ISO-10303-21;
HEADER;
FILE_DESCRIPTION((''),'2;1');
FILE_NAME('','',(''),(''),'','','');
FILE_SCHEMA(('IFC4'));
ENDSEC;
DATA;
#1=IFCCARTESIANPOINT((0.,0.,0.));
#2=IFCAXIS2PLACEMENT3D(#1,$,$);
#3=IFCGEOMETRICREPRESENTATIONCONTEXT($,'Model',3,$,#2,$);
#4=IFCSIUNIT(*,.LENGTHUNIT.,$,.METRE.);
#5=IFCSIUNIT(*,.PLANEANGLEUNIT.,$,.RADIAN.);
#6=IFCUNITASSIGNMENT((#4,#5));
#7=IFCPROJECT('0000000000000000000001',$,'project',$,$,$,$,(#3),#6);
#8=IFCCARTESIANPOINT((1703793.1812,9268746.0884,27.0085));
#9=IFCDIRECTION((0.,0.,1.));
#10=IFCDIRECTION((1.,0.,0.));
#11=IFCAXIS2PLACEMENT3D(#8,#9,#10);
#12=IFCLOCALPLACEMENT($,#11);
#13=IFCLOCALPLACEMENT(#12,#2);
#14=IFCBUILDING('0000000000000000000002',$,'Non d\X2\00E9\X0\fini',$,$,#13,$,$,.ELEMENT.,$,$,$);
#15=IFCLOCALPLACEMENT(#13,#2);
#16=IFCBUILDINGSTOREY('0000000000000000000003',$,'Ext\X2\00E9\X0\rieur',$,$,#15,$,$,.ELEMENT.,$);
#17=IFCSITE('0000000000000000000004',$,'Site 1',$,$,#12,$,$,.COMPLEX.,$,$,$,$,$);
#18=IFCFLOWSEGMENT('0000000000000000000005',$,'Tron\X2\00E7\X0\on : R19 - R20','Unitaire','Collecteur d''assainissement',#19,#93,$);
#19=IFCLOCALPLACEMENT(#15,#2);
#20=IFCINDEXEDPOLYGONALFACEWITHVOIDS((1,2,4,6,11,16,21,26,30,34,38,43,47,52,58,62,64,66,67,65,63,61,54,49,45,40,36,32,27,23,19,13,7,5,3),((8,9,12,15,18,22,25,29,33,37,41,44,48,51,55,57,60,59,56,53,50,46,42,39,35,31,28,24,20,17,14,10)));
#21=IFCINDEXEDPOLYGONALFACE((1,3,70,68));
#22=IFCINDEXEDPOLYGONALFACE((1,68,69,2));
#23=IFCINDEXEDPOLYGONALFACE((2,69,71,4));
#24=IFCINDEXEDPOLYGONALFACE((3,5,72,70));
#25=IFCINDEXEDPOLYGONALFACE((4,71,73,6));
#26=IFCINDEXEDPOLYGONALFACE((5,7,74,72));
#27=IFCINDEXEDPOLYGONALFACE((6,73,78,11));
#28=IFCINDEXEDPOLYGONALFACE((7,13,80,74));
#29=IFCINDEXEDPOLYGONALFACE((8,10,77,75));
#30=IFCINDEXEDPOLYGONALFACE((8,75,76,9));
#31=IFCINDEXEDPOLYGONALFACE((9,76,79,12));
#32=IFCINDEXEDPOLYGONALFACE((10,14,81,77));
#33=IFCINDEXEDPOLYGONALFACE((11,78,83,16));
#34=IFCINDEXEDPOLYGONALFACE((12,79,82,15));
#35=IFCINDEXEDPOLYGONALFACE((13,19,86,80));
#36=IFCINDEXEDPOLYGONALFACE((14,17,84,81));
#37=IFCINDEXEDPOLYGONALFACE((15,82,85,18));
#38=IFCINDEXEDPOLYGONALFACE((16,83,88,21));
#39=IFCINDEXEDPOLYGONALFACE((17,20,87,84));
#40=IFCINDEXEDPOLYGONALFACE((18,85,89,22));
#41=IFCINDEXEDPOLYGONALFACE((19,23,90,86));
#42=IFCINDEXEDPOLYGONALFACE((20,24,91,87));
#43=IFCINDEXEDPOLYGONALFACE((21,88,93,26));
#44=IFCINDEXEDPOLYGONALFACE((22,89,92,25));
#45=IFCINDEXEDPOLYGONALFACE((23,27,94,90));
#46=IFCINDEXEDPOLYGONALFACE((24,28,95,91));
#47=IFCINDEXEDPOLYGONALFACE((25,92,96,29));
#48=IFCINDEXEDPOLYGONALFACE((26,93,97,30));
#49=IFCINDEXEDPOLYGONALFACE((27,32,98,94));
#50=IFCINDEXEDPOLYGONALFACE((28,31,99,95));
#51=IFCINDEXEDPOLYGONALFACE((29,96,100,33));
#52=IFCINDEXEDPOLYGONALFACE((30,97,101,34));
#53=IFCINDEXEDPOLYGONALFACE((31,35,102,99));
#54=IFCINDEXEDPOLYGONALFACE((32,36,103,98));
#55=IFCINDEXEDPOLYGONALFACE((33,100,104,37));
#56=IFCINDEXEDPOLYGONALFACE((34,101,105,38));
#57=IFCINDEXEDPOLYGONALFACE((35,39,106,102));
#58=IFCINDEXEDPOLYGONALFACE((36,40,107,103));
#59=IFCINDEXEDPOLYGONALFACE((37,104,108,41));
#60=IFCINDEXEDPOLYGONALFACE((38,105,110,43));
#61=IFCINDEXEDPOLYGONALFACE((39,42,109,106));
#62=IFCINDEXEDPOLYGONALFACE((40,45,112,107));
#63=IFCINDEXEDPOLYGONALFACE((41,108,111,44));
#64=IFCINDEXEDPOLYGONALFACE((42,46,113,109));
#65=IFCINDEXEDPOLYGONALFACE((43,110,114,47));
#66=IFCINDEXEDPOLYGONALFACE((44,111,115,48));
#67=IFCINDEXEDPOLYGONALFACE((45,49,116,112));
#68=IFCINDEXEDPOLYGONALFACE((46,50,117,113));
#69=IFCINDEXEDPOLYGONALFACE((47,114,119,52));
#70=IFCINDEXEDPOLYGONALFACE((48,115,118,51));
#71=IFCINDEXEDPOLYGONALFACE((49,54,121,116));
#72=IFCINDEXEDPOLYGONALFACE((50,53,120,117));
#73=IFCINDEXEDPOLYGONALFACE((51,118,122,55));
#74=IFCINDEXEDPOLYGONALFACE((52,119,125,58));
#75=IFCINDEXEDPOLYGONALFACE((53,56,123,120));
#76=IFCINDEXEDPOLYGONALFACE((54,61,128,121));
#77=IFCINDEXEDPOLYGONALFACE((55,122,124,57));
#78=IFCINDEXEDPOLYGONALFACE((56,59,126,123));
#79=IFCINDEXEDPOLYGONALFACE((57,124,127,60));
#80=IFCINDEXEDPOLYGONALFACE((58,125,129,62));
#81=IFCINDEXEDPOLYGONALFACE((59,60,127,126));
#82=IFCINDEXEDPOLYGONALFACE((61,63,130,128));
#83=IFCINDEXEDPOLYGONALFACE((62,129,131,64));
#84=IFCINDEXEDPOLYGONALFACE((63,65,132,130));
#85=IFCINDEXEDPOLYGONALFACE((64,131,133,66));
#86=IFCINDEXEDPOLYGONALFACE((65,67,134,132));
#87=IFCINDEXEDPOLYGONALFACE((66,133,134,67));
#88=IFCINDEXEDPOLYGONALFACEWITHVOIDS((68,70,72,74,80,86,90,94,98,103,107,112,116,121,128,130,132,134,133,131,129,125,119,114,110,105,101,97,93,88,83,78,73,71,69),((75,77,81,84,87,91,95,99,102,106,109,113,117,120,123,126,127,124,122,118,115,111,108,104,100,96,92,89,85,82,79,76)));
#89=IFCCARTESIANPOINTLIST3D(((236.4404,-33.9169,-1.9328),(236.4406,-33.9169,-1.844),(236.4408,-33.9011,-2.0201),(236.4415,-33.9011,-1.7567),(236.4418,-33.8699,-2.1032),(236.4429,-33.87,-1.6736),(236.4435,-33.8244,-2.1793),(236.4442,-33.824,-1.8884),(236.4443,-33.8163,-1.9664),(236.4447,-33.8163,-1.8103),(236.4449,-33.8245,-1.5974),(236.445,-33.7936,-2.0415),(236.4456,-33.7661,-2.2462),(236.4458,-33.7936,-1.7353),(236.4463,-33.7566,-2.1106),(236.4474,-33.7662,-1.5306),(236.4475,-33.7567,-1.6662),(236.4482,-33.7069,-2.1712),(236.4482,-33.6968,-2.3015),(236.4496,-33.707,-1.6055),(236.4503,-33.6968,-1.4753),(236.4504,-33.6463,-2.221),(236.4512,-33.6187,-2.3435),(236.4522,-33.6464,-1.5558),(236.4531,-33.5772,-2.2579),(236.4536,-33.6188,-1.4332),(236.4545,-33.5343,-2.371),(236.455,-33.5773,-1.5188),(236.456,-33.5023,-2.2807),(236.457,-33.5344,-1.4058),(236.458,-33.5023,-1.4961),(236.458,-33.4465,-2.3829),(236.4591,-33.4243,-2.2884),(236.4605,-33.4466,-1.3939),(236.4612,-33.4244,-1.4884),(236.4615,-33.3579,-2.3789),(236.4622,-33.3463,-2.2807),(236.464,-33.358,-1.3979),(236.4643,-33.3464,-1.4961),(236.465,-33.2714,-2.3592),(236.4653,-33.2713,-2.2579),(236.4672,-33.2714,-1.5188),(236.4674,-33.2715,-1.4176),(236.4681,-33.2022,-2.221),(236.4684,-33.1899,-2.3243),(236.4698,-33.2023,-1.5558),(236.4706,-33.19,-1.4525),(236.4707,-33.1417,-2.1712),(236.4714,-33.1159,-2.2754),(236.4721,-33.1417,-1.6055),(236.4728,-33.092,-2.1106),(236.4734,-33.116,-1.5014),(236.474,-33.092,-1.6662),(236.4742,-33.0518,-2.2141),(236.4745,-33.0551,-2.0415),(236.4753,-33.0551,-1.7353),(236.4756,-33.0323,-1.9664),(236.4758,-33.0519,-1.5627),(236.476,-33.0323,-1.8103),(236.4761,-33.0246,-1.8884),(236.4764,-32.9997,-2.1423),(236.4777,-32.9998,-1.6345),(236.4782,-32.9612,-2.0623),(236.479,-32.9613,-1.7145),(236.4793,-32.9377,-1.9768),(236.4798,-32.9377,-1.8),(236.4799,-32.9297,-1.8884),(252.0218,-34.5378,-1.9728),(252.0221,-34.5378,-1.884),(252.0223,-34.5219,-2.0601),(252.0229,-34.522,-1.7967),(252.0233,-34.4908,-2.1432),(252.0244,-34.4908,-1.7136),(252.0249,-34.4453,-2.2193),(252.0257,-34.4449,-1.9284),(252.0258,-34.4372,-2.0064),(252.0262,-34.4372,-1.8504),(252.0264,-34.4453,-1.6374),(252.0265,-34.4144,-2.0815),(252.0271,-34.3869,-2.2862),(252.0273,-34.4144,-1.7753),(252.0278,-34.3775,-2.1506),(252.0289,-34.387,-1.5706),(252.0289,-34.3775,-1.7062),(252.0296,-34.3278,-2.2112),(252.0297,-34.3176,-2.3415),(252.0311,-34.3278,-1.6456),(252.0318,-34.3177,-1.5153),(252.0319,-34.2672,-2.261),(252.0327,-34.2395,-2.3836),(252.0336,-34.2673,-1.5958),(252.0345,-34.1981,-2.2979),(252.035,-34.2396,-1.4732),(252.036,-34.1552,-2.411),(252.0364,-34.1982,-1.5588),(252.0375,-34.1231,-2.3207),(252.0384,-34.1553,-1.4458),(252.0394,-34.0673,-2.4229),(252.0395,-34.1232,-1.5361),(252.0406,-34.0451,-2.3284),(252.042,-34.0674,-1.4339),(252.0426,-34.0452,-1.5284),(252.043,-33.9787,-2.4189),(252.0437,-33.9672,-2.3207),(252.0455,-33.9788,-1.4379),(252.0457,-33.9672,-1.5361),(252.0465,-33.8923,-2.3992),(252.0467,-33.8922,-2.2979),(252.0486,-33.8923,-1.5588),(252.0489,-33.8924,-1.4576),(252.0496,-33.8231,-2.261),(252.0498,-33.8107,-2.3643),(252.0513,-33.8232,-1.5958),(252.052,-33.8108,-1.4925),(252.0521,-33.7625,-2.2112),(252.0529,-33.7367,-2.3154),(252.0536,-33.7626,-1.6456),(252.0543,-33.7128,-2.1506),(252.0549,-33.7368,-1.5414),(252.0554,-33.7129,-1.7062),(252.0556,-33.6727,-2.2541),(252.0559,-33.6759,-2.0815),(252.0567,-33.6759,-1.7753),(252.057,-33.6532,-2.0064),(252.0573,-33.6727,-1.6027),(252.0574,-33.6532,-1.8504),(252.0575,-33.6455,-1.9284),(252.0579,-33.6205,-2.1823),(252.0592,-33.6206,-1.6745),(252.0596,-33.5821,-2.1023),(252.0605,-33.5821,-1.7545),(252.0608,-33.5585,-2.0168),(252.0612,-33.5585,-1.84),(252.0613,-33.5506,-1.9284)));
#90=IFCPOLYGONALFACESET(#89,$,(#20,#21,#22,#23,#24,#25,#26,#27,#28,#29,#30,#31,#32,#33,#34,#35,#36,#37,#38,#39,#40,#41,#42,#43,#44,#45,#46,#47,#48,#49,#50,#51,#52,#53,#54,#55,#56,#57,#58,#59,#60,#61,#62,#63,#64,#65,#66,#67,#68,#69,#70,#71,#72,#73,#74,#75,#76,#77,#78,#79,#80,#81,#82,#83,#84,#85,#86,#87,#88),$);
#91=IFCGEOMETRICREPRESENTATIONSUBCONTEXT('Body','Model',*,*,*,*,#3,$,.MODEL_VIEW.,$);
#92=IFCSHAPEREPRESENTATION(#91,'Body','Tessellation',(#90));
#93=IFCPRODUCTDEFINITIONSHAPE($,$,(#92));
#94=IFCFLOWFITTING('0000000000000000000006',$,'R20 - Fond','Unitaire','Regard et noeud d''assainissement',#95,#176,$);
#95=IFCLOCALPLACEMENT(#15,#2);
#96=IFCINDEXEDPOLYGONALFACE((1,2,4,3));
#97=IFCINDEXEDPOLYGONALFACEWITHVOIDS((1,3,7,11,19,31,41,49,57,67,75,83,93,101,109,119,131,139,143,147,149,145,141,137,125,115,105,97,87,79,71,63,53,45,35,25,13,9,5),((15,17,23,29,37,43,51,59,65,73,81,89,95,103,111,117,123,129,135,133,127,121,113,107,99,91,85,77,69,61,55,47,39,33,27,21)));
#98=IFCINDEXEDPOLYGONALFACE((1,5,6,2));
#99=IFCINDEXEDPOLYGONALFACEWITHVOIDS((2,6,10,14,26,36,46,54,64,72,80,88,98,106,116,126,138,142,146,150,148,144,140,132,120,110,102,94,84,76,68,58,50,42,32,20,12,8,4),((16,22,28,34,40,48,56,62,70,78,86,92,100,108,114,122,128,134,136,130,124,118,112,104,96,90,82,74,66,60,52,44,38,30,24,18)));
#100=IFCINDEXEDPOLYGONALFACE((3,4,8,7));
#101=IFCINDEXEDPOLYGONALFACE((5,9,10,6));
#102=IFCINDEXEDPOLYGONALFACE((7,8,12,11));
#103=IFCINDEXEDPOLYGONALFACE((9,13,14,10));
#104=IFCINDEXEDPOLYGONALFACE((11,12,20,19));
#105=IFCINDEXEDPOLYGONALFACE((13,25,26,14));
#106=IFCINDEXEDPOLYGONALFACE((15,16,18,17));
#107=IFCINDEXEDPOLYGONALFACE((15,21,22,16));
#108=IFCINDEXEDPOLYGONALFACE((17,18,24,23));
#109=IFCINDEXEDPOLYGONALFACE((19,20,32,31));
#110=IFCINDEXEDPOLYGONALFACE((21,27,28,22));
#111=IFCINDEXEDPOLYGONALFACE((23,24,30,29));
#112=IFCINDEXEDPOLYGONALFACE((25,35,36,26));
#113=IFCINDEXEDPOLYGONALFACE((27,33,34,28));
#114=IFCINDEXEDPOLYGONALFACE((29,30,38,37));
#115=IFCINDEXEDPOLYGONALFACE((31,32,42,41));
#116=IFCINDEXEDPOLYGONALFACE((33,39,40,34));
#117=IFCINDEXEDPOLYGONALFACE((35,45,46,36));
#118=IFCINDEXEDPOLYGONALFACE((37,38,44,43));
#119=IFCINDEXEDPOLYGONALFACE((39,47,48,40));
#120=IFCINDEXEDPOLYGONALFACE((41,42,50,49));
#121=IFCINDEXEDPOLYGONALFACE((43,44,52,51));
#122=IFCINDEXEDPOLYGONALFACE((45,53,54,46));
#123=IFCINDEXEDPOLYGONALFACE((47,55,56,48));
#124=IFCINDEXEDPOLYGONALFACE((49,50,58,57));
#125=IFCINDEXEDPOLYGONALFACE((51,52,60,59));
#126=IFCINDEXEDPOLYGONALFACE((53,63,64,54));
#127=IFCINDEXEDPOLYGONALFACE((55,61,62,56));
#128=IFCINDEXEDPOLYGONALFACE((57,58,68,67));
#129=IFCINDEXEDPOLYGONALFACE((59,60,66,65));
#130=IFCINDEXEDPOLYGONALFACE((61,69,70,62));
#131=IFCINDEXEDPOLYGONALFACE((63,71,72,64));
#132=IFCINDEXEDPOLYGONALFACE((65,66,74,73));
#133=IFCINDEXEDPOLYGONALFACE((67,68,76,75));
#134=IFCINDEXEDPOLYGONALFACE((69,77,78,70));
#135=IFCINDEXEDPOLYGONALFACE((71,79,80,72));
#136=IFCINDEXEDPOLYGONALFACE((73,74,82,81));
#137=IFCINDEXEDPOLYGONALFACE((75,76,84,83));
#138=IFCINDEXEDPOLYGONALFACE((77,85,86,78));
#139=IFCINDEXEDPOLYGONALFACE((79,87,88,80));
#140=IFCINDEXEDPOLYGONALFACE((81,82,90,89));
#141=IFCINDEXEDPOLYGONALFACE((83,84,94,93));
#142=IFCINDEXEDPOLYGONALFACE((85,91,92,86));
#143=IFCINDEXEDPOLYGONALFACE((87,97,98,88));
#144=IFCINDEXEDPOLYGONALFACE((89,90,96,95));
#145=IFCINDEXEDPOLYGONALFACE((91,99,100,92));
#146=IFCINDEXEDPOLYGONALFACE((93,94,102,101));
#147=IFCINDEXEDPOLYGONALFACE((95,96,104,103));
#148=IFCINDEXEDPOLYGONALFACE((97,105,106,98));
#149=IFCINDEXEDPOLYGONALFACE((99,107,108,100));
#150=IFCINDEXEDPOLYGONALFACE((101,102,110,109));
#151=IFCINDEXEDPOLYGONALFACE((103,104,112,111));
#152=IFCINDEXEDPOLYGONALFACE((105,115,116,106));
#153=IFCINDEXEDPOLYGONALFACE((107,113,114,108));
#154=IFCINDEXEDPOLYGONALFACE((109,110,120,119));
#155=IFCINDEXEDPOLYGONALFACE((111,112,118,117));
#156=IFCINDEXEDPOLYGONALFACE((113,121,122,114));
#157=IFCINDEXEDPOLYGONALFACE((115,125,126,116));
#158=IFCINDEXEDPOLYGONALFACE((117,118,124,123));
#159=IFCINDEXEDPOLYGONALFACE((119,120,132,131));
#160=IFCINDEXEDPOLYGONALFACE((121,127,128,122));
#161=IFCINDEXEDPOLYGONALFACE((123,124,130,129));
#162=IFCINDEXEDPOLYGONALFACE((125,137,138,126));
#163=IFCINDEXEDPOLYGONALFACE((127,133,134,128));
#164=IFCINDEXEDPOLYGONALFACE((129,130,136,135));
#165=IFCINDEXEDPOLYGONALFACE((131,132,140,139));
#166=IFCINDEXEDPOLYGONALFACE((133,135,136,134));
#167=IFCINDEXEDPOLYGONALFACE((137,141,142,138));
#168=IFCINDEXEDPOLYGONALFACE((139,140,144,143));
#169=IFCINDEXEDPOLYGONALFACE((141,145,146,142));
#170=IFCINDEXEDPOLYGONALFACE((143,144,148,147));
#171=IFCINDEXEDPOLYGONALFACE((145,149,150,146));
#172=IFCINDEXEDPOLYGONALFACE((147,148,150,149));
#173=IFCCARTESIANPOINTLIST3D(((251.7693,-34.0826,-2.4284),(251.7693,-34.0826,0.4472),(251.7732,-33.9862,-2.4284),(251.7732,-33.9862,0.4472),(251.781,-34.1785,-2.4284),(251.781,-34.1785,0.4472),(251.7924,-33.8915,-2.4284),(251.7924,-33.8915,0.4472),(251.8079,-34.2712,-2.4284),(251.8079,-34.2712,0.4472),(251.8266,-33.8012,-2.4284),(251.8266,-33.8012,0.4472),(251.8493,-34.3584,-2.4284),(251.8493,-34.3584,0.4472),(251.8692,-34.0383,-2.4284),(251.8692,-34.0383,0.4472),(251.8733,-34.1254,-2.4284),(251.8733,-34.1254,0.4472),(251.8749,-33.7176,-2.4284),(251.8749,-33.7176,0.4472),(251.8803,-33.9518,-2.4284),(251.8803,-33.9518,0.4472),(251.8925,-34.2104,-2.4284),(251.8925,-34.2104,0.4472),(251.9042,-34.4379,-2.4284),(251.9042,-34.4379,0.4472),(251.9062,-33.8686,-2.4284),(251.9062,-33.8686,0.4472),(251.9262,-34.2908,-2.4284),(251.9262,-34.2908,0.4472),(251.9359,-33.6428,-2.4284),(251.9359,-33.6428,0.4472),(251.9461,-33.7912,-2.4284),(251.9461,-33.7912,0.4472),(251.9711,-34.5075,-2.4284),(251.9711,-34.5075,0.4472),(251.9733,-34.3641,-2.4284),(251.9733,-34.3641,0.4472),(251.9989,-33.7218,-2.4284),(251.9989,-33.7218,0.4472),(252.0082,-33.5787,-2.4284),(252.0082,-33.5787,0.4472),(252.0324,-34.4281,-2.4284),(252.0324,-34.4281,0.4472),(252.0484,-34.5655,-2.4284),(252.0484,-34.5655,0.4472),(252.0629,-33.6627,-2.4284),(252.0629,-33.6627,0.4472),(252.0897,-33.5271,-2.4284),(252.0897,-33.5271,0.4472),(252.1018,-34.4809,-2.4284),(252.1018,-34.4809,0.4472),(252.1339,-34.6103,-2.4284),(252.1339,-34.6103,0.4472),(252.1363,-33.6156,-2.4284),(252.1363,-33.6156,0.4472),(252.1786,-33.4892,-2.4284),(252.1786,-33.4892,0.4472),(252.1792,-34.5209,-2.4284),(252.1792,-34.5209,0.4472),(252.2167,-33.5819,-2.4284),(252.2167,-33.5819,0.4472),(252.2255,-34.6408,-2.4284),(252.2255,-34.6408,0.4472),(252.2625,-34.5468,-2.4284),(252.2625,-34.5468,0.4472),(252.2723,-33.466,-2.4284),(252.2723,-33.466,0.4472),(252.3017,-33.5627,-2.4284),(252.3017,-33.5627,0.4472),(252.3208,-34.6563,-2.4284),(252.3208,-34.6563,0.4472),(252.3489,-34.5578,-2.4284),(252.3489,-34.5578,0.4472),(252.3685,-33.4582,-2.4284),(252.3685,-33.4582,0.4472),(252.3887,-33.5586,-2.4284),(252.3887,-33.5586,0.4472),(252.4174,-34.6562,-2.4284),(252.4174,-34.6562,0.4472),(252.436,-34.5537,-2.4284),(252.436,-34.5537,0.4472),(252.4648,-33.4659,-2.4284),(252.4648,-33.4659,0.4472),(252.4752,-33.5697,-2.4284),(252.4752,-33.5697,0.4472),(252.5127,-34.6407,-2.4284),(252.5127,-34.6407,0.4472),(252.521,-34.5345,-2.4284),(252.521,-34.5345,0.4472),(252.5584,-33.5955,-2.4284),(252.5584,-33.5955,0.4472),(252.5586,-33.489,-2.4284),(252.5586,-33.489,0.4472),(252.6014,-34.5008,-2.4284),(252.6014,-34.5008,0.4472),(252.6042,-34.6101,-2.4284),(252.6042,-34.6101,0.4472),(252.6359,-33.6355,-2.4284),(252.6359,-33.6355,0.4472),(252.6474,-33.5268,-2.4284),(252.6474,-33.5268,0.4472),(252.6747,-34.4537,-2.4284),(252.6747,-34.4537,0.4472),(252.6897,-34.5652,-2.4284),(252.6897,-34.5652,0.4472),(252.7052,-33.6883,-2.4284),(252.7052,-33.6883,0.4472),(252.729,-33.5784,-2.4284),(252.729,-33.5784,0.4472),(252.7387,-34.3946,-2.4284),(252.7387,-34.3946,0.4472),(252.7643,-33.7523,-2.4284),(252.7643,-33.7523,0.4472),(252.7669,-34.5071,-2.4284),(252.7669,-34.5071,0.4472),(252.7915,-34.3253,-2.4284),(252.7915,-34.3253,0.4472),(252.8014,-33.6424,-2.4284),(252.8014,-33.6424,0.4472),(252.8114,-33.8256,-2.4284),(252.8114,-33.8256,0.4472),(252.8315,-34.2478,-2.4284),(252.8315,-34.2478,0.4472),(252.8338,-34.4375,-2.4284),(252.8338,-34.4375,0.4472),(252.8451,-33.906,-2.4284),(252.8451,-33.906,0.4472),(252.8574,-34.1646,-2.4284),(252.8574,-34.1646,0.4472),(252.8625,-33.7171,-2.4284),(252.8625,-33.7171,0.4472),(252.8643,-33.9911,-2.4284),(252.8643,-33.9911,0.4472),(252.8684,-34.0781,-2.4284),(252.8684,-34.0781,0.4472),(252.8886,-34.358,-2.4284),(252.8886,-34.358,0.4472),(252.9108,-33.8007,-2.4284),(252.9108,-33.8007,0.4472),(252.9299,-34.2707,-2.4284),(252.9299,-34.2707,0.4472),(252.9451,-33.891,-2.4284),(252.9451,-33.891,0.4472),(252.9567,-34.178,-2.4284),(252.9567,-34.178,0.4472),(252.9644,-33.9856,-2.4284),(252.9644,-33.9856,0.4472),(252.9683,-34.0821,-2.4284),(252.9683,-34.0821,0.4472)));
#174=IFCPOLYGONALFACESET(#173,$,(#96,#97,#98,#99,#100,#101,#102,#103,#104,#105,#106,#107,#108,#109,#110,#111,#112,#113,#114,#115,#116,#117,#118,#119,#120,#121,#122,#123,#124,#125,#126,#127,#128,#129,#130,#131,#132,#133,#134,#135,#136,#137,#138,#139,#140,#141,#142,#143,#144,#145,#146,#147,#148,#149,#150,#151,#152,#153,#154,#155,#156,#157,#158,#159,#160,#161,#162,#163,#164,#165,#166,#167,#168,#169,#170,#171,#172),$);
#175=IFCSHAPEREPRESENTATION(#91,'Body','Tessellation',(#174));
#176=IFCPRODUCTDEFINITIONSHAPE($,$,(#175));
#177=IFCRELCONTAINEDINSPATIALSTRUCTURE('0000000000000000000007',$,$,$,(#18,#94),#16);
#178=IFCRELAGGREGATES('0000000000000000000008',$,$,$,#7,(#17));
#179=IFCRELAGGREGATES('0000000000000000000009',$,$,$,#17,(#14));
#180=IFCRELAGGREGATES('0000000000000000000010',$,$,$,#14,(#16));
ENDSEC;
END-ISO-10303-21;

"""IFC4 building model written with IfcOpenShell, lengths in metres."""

from ifc_helpers import new_model, si_unit, frame, origin, origin_2d, place, context, subcontext, project, spatial, hollow_circle, extrude, element, save


model = new_model("IFC4")

# Units and contexts
model_context = context("Model", 3, world=origin())
body_context = subcontext(model_context, "Body", "Model", "MODEL_VIEW")
ifc_project = project(units=[si_unit("LENGTHUNIT", "METRE"), si_unit("PLANEANGLEUNIT", "RADIAN")], contexts=[model_context])

# Site, building, storey
site_placement = place(None, frame((1703793.1812, 9268746.0884, 27.0085), z_axis=(0.0, 0.0, 1.0), x_axis=(1.0, 0.0, 0.0)))
site = spatial("IfcSite", under=ifc_project, at=site_placement, Name="Site 1", CompositionType="COMPLEX")
building_placement = place(site_placement, origin())
building = spatial("IfcBuilding", under=site, at=building_placement, Name="Non défini", CompositionType="ELEMENT")
storey_placement = place(building_placement, origin())
storey = spatial("IfcBuildingStorey", under=building, at=storey_placement, Name="Extérieur", CompositionType="ELEMENT")

# Flow segment
flow_segment_1_placement = place(storey_placement, origin())
element("IfcFlowSegment", 1, at=flow_segment_1_placement, inside=storey, Name="Tronçon : R19 - R20", Description="Unitaire", ObjectType="Collecteur d'assainissement", context=body_context, shape_type="SweptSolid", body=[
    extrude(hollow_circle(Radius=0.495, WallThickness=0.095, at=origin_2d()), frame((236.4601, -33.4243, -1.8884), z_axis=(0.999204, -0.039813, -0.002566), x_axis=(0.039814, 0.999207, 0.0)), (0.0, 0.0, 1.0), 15.5939),
])

# Flow fitting
flow_fitting_1_placement = place(storey_placement, origin())
element("IfcFlowFitting", 2, at=flow_fitting_1_placement, inside=storey, Name="R20 - Fond", Description="Unitaire", ObjectType="Regard et noeud d'assainissement", context=body_context, shape_type="SweptSolid", body=[
    extrude(hollow_circle(Radius=0.6, WallThickness=0.1, at=origin_2d()), frame((252.3688, -34.0582, -2.4284), z_axis=(0.0, 0.0, 1.0), x_axis=(0.999207, -0.039814, 0.0)), (0.0, 0.0, 1.0), 2.8756),
])

save(model, "model.ifc")
